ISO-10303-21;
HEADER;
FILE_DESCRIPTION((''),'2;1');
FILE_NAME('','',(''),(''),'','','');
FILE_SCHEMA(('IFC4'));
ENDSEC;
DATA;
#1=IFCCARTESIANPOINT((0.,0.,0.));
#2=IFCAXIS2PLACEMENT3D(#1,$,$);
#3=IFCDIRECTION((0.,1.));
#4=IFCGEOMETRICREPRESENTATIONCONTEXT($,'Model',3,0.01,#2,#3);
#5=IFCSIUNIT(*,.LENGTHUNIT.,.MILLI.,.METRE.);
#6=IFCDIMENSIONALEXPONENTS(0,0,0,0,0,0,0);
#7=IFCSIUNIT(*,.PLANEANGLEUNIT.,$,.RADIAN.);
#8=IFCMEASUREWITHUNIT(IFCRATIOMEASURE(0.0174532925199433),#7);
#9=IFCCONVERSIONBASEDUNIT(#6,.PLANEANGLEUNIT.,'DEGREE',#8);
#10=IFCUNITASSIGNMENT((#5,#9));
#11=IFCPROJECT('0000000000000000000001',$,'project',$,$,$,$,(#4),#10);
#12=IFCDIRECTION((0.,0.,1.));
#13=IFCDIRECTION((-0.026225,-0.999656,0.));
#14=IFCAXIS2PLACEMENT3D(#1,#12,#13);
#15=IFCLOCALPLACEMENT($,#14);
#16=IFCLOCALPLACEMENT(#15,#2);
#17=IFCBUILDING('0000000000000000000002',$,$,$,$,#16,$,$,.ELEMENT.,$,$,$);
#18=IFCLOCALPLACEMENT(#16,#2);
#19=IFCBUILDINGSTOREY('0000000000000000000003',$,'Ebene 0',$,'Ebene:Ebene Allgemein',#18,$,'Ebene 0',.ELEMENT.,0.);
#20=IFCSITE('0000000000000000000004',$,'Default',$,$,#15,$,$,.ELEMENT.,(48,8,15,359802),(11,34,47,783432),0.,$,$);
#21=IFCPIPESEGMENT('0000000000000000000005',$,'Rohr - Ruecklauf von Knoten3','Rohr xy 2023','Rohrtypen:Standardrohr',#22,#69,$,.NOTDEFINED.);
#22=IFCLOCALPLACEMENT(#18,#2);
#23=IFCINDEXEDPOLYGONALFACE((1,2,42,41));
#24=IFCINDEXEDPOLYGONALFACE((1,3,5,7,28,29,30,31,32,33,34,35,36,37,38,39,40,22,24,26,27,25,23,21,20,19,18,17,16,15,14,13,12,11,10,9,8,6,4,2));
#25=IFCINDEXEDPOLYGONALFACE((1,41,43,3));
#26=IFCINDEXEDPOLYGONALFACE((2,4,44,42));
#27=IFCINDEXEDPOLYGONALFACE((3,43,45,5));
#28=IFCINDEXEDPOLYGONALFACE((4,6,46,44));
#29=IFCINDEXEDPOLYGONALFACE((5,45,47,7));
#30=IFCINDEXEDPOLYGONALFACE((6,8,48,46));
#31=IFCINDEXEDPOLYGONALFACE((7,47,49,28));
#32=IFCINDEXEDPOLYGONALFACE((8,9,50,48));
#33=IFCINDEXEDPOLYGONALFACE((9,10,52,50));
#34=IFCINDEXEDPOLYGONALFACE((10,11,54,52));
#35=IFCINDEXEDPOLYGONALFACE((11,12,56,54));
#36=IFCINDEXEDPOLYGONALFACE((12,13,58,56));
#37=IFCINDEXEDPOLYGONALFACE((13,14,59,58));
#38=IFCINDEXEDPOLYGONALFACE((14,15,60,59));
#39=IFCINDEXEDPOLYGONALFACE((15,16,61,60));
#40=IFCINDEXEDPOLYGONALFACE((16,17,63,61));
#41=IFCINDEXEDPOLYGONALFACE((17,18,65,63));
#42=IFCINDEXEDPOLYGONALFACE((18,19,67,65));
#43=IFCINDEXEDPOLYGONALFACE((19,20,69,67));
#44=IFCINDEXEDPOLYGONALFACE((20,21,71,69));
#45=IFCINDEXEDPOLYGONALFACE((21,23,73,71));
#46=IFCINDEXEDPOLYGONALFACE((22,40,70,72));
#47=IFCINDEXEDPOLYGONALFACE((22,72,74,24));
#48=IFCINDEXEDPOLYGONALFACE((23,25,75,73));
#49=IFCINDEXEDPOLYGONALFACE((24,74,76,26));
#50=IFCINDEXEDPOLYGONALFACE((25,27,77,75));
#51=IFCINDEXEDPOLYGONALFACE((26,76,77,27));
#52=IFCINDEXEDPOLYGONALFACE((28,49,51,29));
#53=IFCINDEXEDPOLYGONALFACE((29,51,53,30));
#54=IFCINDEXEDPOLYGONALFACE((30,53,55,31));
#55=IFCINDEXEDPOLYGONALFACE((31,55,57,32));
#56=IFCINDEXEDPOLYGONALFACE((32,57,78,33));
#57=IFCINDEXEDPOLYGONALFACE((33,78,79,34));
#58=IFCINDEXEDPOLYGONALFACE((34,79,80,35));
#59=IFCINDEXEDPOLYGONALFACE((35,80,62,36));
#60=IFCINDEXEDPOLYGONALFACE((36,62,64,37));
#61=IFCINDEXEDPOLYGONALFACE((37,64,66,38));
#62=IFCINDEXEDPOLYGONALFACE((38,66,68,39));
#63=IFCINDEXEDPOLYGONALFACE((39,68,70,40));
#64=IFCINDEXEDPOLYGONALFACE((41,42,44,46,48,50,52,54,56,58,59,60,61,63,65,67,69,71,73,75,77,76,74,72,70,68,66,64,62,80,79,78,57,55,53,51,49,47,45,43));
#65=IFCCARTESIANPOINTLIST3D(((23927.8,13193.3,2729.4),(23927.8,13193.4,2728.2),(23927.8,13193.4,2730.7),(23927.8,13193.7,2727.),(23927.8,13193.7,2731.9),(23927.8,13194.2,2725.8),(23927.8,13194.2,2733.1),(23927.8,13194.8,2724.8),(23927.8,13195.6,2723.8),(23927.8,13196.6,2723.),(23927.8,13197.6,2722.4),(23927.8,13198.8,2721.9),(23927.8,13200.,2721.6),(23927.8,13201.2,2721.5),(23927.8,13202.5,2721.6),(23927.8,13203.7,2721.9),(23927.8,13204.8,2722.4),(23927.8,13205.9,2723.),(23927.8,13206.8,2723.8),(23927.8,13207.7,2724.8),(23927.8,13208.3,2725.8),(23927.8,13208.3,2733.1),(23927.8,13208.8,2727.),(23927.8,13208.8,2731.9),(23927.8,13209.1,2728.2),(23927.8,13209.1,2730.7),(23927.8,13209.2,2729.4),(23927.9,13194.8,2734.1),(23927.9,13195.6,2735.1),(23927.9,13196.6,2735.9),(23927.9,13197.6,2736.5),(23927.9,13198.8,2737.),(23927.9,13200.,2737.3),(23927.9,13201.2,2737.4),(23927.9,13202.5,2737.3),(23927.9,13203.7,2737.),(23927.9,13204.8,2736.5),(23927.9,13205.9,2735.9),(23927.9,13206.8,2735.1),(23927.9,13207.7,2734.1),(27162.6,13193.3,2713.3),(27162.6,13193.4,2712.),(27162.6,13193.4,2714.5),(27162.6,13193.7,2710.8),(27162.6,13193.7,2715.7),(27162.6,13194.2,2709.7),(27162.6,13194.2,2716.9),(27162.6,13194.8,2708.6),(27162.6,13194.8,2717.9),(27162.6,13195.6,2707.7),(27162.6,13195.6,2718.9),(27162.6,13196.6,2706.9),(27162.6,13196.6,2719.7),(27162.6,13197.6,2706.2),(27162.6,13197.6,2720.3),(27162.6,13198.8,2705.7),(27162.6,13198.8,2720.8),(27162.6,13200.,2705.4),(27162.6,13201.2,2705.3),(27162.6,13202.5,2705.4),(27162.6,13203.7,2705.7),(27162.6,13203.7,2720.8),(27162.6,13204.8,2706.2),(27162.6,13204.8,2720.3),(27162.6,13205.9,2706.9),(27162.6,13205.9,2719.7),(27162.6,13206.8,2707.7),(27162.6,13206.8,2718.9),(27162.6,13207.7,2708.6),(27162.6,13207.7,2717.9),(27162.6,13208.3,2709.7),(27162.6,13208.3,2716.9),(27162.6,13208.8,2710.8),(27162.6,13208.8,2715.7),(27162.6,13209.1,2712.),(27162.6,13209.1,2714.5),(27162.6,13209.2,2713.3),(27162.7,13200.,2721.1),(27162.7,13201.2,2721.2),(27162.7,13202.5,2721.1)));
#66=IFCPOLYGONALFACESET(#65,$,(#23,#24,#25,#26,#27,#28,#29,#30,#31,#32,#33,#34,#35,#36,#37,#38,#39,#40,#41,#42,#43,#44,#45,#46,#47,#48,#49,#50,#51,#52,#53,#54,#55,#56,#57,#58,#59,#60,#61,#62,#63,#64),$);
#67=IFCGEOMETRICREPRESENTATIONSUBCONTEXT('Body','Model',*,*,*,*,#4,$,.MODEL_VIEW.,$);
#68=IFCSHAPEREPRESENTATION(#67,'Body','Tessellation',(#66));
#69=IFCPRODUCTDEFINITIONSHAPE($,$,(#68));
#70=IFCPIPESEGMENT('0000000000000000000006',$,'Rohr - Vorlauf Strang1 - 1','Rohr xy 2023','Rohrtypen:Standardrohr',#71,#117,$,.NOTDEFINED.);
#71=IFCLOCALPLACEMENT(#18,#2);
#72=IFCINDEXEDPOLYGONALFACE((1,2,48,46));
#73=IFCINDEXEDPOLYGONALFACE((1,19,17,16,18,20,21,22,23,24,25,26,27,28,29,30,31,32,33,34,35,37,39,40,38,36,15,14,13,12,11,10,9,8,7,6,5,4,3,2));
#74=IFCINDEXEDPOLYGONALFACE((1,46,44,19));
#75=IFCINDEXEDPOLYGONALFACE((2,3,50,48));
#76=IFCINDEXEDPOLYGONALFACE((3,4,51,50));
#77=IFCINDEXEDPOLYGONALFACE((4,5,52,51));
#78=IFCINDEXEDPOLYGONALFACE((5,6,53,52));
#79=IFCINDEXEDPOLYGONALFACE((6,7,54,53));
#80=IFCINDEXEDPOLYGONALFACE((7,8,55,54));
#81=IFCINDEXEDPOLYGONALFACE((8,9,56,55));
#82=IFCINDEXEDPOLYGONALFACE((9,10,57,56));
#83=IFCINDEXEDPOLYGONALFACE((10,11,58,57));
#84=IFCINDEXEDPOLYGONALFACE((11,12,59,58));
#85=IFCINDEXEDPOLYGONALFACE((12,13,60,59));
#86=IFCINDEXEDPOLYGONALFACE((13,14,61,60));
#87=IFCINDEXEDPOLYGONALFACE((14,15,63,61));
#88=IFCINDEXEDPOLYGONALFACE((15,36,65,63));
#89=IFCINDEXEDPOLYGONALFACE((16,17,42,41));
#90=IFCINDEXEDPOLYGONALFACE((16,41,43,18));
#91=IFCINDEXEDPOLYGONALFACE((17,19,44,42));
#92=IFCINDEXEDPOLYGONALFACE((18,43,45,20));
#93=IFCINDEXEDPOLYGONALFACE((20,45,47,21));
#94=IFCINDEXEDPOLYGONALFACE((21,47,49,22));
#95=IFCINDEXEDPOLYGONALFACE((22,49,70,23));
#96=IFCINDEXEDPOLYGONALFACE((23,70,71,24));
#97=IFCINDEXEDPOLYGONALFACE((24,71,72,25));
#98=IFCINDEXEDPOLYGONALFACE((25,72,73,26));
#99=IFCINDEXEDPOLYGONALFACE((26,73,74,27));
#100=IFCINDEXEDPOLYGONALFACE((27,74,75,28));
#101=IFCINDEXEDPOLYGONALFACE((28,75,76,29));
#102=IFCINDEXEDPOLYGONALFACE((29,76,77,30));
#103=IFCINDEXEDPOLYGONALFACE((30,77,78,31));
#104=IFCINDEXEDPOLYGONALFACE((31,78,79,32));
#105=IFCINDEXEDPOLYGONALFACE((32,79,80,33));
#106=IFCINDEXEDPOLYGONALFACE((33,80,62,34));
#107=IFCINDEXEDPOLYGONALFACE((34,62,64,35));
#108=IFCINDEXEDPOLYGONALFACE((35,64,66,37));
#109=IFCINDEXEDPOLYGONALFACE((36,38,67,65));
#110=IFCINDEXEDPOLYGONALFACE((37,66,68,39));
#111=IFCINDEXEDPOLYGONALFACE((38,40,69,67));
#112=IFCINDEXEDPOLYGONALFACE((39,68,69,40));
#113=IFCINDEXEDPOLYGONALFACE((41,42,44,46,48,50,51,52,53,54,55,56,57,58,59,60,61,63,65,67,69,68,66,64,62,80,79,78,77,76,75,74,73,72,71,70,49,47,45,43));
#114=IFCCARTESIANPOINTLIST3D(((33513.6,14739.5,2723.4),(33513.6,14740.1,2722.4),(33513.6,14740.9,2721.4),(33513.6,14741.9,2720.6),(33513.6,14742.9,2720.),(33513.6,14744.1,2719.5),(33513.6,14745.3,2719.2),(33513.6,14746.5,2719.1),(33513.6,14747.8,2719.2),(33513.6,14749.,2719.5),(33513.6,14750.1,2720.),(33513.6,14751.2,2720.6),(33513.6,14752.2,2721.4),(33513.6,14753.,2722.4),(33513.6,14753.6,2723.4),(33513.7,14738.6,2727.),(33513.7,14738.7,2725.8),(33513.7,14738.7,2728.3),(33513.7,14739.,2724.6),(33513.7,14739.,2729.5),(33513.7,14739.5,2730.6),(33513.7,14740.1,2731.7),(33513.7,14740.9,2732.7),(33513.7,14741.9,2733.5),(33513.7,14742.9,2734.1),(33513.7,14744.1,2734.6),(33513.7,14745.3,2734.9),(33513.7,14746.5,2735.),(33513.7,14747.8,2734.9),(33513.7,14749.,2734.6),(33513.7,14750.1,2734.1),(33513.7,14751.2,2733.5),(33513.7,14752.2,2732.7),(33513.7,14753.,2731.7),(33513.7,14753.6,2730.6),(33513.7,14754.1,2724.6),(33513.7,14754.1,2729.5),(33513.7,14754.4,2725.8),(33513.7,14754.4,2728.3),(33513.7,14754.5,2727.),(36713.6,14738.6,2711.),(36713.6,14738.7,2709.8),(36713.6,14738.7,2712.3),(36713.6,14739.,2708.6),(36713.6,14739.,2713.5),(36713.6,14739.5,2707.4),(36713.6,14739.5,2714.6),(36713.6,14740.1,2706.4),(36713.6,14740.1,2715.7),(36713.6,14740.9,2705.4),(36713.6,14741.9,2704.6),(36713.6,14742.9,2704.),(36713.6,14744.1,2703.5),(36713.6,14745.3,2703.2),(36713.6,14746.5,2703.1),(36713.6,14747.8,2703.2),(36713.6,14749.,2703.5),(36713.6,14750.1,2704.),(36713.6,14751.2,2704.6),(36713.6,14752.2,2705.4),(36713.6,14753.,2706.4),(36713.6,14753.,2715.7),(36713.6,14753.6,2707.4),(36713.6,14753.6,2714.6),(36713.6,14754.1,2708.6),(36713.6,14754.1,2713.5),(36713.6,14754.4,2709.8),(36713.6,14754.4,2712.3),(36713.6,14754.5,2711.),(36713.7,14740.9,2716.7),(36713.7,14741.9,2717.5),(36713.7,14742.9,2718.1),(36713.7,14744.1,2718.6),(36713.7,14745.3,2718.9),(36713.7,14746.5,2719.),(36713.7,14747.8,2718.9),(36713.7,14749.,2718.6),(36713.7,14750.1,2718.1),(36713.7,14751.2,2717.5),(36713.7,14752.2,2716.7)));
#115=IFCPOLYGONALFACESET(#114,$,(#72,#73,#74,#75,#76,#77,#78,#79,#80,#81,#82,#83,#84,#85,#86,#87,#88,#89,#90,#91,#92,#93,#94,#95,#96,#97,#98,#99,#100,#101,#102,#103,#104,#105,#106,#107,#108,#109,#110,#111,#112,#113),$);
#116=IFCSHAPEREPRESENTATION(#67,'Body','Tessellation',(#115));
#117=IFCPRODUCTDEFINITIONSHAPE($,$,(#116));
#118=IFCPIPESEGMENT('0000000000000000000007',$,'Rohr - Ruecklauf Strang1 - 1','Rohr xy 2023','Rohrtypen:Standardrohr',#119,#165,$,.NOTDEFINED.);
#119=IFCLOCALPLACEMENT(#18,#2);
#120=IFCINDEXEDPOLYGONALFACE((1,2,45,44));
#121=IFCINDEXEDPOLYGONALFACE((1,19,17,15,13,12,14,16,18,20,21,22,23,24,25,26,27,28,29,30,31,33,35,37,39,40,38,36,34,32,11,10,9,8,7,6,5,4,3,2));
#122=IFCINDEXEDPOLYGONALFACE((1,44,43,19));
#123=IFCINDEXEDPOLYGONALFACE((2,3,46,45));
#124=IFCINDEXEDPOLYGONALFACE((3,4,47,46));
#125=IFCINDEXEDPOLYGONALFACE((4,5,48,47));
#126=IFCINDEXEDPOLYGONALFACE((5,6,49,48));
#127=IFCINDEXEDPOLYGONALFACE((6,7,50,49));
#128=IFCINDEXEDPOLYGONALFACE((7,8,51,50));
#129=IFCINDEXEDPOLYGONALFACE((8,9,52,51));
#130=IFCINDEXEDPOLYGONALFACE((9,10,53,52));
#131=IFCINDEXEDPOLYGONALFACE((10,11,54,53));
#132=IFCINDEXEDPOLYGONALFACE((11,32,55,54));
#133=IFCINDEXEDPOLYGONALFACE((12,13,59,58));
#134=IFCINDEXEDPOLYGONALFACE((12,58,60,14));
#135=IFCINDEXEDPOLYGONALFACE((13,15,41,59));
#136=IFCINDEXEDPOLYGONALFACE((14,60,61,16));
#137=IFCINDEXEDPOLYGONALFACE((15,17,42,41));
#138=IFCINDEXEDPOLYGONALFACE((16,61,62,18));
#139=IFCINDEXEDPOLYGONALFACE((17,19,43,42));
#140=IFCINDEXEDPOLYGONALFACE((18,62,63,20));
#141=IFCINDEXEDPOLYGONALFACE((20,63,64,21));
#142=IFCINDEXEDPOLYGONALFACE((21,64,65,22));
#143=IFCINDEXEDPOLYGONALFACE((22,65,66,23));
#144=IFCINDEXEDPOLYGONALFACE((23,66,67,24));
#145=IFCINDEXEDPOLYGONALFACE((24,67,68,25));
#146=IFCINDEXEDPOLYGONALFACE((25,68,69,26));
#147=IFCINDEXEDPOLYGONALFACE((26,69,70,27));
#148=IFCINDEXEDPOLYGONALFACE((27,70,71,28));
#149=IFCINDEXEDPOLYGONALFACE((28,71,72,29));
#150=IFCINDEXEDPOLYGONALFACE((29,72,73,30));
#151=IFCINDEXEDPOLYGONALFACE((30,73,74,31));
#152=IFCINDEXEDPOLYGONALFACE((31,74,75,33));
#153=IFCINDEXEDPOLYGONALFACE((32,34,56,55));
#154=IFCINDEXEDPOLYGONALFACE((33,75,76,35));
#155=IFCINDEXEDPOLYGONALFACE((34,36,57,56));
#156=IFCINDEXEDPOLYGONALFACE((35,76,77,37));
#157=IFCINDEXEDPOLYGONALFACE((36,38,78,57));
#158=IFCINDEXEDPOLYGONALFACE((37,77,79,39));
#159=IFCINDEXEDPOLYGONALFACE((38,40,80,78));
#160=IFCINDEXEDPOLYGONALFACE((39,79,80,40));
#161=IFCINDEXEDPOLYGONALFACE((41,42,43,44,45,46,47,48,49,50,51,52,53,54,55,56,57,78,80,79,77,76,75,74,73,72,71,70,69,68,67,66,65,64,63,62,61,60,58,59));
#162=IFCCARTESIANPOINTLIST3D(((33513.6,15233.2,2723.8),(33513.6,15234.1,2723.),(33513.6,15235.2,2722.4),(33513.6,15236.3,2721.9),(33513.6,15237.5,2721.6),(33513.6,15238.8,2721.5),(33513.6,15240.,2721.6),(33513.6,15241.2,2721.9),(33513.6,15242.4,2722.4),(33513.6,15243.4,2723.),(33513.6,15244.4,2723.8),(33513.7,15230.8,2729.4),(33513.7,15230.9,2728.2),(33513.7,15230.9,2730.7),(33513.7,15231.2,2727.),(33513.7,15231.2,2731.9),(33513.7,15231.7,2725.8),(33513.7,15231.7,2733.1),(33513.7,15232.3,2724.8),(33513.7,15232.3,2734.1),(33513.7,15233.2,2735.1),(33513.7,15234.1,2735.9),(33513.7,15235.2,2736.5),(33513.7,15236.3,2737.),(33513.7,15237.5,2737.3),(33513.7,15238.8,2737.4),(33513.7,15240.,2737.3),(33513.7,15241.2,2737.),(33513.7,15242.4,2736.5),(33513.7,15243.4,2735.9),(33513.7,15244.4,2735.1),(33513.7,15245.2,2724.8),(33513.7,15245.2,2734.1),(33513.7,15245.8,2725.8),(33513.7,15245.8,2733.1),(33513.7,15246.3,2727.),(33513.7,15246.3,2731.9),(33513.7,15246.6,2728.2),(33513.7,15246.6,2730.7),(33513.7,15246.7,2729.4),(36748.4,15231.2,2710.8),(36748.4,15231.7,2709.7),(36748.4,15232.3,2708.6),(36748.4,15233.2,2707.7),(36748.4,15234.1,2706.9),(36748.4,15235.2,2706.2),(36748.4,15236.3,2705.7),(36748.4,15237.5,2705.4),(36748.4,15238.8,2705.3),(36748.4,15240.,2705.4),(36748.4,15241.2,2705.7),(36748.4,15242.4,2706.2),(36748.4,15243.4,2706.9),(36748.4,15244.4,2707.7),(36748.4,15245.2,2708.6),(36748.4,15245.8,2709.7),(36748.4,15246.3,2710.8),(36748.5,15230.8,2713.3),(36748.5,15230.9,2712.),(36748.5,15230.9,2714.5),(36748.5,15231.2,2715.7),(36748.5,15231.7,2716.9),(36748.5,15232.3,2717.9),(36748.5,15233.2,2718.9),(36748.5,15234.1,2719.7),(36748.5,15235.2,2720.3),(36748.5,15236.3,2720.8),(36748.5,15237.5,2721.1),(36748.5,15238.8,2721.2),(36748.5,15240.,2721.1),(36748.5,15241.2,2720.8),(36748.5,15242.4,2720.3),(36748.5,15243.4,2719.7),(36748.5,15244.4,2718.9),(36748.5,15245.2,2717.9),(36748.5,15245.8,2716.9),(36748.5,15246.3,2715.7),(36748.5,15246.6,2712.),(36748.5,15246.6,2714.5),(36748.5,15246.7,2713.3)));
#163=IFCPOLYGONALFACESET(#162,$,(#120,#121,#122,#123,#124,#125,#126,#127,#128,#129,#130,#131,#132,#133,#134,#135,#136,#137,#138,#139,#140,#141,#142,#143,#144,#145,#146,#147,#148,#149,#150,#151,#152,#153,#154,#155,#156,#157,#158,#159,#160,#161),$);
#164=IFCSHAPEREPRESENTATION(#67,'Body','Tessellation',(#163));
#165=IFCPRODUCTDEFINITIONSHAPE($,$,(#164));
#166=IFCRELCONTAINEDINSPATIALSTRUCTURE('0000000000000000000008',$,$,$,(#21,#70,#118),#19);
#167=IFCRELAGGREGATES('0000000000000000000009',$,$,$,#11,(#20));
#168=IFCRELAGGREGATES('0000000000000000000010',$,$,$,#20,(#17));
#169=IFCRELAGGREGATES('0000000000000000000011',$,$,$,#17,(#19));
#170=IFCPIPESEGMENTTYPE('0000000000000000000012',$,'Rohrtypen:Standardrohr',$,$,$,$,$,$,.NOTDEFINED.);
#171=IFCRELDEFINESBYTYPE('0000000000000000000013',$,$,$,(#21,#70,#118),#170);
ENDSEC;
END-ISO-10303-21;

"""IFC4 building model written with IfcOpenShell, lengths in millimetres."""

from ifc_helpers import new_model, entity, si_unit, converted_unit, direction, frame, origin, place, context, subcontext, project, spatial, indexed_curve, outline, extrude, type_object, element, save


model = new_model("IFC4")

# Units and contexts
model_context = context("Model", 3, precision=0.01, world=origin(), true_north=direction((0.0, 1.0)))
body_context = subcontext(model_context, "Body", "Model", "MODEL_VIEW")
ifc_project = project(units=[si_unit("LENGTHUNIT", "METRE", prefix="MILLI"), converted_unit("PLANEANGLEUNIT", "DEGREE", entity("IfcRatioMeasure", 0.0174532925199433), si_unit("PLANEANGLEUNIT", "RADIAN"), dimensions=[0, 0, 0, 0, 0, 0, 0])], contexts=[model_context])

# Site, building, storey
site_placement = place(None, frame((0.0, 0.0, 0.0), z_axis=(0.0, 0.0, 1.0), x_axis=(-0.026225, -0.999656, 0.0)))
site = spatial("IfcSite", under=ifc_project, at=site_placement, Name="Default", CompositionType="ELEMENT", RefLatitude=(48, 8, 15, 359802), RefLongitude=(11, 34, 47, 783432), RefElevation=0.0)
building_placement = place(site_placement, origin())
building = spatial("IfcBuilding", under=site, at=building_placement, CompositionType="ELEMENT")
storey_placement = place(building_placement, origin())
storey = spatial("IfcBuildingStorey", under=building, at=storey_placement, Name="Ebene 0", ObjectType="Ebene:Ebene Allgemein", LongName="Ebene 0", CompositionType="ELEMENT", Elevation=0.0)

# Pipe segments
pipe_segment_type = type_object("IfcPipeSegmentType", Name="Rohrtypen:Standardrohr", PredefinedType="NOTDEFINED")
pipe_segment_1_placement = place(storey_placement, origin())
element("IfcPipeSegment", 1, at=pipe_segment_1_placement, inside=storey, type_object=pipe_segment_type, Name="Rohr - Ruecklauf von Knoten3", Description="Rohr xy 2023", ObjectType="Rohrtypen:Standardrohr", PredefinedType="NOTDEFINED", context=body_context, shape_type="SweptSolid", body=[
    extrude(outline(indexed_curve([(7.9, 0.0), (7.8, 1.2), (7.6, 2.5), (7.1, 3.6), (6.4, 4.7), (5.6, 5.6), (4.7, 6.4), (3.6, 7.1), (2.5, 7.6), (1.2, 7.8), (0.0, 7.9), (-1.2, 7.8), (-2.5, 7.6), (-3.6, 7.1), (-4.7, 6.4), (-5.6, 5.6), (-6.4, 4.7), (-7.1, 3.6), (-7.6, 2.5), (-7.8, 1.2), (-7.9, 0.0), (-7.8, -1.2), (-7.6, -2.5), (-7.1, -3.6), (-6.4, -4.7), (-5.6, -5.6), (-4.7, -6.4), (-3.6, -7.1), (-2.5, -7.6), (-1.2, -7.8), (0.0, -7.9), (1.2, -7.8), (2.5, -7.6), (3.6, -7.1), (4.7, -6.4), (5.6, -5.6), (6.4, -4.7), (7.1, -3.6), (7.6, -2.5), (7.8, -1.2), (7.9, 0.0)], self_intersect=False)), frame((27162.6, 13201.2, 2713.3), z_axis=(-0.999988, 0.0, 0.005), x_axis=(0.0, 1.0, 0.0)), (0.0, 0.0, 1.0), 3234.8),
])
pipe_segment_2_placement = place(storey_placement, origin())
element("IfcPipeSegment", 2, at=pipe_segment_2_placement, inside=storey, type_object=pipe_segment_type, Name="Rohr - Vorlauf Strang1 - 1", Description="Rohr xy 2023", ObjectType="Rohrtypen:Standardrohr", PredefinedType="NOTDEFINED", context=body_context, shape_type="SweptSolid", body=[
    extrude(outline(indexed_curve([(7.9, 0.0), (7.8, 1.2), (7.6, 2.5), (7.1, 3.6), (6.4, 4.7), (5.6, 5.6), (4.7, 6.4), (3.6, 7.1), (2.5, 7.6), (1.2, 7.8), (0.0, 7.9), (-1.2, 7.8), (-2.5, 7.6), (-3.6, 7.1), (-4.7, 6.4), (-5.6, 5.6), (-6.4, 4.7), (-7.1, 3.6), (-7.6, 2.5), (-7.8, 1.2), (-7.9, 0.0), (-7.8, -1.2), (-7.6, -2.5), (-7.1, -3.6), (-6.4, -4.7), (-5.6, -5.6), (-4.7, -6.4), (-3.6, -7.1), (-2.5, -7.6), (-1.2, -7.8), (0.0, -7.9), (1.2, -7.8), (2.5, -7.6), (3.6, -7.1), (4.7, -6.4), (5.6, -5.6), (6.4, -4.7), (7.1, -3.6), (7.6, -2.5), (7.8, -1.2), (7.9, 0.0)], self_intersect=False)), frame((36713.6, 14746.5, 2711.0), z_axis=(-0.999988, 0.0, 0.005), x_axis=(0.0, 1.0, 0.0)), (0.0, 0.0, 1.0), 3200.0),
])
pipe_segment_3_placement = place(storey_placement, origin())
element("IfcPipeSegment", 3, at=pipe_segment_3_placement, inside=storey, type_object=pipe_segment_type, Name="Rohr - Ruecklauf Strang1 - 1", Description="Rohr xy 2023", ObjectType="Rohrtypen:Standardrohr", PredefinedType="NOTDEFINED", context=body_context, shape_type="SweptSolid", body=[
    extrude(outline(indexed_curve([(7.9, 0.0), (7.8, 1.2), (7.6, 2.5), (7.1, 3.6), (6.4, 4.7), (5.6, 5.6), (4.7, 6.4), (3.6, 7.1), (2.5, 7.6), (1.2, 7.8), (0.0, 7.9), (-1.2, 7.8), (-2.5, 7.6), (-3.6, 7.1), (-4.7, 6.4), (-5.6, 5.6), (-6.4, 4.7), (-7.1, 3.6), (-7.6, 2.5), (-7.8, 1.2), (-7.9, 0.0), (-7.8, -1.2), (-7.6, -2.5), (-7.1, -3.6), (-6.4, -4.7), (-5.6, -5.6), (-4.7, -6.4), (-3.6, -7.1), (-2.5, -7.6), (-1.2, -7.8), (0.0, -7.9), (1.2, -7.8), (2.5, -7.6), (3.6, -7.1), (4.7, -6.4), (5.6, -5.6), (6.4, -4.7), (7.1, -3.6), (7.6, -2.5), (7.8, -1.2), (7.9, 0.0)], self_intersect=False)), frame((36748.5, 15238.8, 2713.3), z_axis=(-0.999988, 0.0, 0.005), x_axis=(0.0, 1.0, 0.0)), (0.0, 0.0, 1.0), 3234.8),
])

save(model, "model.ifc")
